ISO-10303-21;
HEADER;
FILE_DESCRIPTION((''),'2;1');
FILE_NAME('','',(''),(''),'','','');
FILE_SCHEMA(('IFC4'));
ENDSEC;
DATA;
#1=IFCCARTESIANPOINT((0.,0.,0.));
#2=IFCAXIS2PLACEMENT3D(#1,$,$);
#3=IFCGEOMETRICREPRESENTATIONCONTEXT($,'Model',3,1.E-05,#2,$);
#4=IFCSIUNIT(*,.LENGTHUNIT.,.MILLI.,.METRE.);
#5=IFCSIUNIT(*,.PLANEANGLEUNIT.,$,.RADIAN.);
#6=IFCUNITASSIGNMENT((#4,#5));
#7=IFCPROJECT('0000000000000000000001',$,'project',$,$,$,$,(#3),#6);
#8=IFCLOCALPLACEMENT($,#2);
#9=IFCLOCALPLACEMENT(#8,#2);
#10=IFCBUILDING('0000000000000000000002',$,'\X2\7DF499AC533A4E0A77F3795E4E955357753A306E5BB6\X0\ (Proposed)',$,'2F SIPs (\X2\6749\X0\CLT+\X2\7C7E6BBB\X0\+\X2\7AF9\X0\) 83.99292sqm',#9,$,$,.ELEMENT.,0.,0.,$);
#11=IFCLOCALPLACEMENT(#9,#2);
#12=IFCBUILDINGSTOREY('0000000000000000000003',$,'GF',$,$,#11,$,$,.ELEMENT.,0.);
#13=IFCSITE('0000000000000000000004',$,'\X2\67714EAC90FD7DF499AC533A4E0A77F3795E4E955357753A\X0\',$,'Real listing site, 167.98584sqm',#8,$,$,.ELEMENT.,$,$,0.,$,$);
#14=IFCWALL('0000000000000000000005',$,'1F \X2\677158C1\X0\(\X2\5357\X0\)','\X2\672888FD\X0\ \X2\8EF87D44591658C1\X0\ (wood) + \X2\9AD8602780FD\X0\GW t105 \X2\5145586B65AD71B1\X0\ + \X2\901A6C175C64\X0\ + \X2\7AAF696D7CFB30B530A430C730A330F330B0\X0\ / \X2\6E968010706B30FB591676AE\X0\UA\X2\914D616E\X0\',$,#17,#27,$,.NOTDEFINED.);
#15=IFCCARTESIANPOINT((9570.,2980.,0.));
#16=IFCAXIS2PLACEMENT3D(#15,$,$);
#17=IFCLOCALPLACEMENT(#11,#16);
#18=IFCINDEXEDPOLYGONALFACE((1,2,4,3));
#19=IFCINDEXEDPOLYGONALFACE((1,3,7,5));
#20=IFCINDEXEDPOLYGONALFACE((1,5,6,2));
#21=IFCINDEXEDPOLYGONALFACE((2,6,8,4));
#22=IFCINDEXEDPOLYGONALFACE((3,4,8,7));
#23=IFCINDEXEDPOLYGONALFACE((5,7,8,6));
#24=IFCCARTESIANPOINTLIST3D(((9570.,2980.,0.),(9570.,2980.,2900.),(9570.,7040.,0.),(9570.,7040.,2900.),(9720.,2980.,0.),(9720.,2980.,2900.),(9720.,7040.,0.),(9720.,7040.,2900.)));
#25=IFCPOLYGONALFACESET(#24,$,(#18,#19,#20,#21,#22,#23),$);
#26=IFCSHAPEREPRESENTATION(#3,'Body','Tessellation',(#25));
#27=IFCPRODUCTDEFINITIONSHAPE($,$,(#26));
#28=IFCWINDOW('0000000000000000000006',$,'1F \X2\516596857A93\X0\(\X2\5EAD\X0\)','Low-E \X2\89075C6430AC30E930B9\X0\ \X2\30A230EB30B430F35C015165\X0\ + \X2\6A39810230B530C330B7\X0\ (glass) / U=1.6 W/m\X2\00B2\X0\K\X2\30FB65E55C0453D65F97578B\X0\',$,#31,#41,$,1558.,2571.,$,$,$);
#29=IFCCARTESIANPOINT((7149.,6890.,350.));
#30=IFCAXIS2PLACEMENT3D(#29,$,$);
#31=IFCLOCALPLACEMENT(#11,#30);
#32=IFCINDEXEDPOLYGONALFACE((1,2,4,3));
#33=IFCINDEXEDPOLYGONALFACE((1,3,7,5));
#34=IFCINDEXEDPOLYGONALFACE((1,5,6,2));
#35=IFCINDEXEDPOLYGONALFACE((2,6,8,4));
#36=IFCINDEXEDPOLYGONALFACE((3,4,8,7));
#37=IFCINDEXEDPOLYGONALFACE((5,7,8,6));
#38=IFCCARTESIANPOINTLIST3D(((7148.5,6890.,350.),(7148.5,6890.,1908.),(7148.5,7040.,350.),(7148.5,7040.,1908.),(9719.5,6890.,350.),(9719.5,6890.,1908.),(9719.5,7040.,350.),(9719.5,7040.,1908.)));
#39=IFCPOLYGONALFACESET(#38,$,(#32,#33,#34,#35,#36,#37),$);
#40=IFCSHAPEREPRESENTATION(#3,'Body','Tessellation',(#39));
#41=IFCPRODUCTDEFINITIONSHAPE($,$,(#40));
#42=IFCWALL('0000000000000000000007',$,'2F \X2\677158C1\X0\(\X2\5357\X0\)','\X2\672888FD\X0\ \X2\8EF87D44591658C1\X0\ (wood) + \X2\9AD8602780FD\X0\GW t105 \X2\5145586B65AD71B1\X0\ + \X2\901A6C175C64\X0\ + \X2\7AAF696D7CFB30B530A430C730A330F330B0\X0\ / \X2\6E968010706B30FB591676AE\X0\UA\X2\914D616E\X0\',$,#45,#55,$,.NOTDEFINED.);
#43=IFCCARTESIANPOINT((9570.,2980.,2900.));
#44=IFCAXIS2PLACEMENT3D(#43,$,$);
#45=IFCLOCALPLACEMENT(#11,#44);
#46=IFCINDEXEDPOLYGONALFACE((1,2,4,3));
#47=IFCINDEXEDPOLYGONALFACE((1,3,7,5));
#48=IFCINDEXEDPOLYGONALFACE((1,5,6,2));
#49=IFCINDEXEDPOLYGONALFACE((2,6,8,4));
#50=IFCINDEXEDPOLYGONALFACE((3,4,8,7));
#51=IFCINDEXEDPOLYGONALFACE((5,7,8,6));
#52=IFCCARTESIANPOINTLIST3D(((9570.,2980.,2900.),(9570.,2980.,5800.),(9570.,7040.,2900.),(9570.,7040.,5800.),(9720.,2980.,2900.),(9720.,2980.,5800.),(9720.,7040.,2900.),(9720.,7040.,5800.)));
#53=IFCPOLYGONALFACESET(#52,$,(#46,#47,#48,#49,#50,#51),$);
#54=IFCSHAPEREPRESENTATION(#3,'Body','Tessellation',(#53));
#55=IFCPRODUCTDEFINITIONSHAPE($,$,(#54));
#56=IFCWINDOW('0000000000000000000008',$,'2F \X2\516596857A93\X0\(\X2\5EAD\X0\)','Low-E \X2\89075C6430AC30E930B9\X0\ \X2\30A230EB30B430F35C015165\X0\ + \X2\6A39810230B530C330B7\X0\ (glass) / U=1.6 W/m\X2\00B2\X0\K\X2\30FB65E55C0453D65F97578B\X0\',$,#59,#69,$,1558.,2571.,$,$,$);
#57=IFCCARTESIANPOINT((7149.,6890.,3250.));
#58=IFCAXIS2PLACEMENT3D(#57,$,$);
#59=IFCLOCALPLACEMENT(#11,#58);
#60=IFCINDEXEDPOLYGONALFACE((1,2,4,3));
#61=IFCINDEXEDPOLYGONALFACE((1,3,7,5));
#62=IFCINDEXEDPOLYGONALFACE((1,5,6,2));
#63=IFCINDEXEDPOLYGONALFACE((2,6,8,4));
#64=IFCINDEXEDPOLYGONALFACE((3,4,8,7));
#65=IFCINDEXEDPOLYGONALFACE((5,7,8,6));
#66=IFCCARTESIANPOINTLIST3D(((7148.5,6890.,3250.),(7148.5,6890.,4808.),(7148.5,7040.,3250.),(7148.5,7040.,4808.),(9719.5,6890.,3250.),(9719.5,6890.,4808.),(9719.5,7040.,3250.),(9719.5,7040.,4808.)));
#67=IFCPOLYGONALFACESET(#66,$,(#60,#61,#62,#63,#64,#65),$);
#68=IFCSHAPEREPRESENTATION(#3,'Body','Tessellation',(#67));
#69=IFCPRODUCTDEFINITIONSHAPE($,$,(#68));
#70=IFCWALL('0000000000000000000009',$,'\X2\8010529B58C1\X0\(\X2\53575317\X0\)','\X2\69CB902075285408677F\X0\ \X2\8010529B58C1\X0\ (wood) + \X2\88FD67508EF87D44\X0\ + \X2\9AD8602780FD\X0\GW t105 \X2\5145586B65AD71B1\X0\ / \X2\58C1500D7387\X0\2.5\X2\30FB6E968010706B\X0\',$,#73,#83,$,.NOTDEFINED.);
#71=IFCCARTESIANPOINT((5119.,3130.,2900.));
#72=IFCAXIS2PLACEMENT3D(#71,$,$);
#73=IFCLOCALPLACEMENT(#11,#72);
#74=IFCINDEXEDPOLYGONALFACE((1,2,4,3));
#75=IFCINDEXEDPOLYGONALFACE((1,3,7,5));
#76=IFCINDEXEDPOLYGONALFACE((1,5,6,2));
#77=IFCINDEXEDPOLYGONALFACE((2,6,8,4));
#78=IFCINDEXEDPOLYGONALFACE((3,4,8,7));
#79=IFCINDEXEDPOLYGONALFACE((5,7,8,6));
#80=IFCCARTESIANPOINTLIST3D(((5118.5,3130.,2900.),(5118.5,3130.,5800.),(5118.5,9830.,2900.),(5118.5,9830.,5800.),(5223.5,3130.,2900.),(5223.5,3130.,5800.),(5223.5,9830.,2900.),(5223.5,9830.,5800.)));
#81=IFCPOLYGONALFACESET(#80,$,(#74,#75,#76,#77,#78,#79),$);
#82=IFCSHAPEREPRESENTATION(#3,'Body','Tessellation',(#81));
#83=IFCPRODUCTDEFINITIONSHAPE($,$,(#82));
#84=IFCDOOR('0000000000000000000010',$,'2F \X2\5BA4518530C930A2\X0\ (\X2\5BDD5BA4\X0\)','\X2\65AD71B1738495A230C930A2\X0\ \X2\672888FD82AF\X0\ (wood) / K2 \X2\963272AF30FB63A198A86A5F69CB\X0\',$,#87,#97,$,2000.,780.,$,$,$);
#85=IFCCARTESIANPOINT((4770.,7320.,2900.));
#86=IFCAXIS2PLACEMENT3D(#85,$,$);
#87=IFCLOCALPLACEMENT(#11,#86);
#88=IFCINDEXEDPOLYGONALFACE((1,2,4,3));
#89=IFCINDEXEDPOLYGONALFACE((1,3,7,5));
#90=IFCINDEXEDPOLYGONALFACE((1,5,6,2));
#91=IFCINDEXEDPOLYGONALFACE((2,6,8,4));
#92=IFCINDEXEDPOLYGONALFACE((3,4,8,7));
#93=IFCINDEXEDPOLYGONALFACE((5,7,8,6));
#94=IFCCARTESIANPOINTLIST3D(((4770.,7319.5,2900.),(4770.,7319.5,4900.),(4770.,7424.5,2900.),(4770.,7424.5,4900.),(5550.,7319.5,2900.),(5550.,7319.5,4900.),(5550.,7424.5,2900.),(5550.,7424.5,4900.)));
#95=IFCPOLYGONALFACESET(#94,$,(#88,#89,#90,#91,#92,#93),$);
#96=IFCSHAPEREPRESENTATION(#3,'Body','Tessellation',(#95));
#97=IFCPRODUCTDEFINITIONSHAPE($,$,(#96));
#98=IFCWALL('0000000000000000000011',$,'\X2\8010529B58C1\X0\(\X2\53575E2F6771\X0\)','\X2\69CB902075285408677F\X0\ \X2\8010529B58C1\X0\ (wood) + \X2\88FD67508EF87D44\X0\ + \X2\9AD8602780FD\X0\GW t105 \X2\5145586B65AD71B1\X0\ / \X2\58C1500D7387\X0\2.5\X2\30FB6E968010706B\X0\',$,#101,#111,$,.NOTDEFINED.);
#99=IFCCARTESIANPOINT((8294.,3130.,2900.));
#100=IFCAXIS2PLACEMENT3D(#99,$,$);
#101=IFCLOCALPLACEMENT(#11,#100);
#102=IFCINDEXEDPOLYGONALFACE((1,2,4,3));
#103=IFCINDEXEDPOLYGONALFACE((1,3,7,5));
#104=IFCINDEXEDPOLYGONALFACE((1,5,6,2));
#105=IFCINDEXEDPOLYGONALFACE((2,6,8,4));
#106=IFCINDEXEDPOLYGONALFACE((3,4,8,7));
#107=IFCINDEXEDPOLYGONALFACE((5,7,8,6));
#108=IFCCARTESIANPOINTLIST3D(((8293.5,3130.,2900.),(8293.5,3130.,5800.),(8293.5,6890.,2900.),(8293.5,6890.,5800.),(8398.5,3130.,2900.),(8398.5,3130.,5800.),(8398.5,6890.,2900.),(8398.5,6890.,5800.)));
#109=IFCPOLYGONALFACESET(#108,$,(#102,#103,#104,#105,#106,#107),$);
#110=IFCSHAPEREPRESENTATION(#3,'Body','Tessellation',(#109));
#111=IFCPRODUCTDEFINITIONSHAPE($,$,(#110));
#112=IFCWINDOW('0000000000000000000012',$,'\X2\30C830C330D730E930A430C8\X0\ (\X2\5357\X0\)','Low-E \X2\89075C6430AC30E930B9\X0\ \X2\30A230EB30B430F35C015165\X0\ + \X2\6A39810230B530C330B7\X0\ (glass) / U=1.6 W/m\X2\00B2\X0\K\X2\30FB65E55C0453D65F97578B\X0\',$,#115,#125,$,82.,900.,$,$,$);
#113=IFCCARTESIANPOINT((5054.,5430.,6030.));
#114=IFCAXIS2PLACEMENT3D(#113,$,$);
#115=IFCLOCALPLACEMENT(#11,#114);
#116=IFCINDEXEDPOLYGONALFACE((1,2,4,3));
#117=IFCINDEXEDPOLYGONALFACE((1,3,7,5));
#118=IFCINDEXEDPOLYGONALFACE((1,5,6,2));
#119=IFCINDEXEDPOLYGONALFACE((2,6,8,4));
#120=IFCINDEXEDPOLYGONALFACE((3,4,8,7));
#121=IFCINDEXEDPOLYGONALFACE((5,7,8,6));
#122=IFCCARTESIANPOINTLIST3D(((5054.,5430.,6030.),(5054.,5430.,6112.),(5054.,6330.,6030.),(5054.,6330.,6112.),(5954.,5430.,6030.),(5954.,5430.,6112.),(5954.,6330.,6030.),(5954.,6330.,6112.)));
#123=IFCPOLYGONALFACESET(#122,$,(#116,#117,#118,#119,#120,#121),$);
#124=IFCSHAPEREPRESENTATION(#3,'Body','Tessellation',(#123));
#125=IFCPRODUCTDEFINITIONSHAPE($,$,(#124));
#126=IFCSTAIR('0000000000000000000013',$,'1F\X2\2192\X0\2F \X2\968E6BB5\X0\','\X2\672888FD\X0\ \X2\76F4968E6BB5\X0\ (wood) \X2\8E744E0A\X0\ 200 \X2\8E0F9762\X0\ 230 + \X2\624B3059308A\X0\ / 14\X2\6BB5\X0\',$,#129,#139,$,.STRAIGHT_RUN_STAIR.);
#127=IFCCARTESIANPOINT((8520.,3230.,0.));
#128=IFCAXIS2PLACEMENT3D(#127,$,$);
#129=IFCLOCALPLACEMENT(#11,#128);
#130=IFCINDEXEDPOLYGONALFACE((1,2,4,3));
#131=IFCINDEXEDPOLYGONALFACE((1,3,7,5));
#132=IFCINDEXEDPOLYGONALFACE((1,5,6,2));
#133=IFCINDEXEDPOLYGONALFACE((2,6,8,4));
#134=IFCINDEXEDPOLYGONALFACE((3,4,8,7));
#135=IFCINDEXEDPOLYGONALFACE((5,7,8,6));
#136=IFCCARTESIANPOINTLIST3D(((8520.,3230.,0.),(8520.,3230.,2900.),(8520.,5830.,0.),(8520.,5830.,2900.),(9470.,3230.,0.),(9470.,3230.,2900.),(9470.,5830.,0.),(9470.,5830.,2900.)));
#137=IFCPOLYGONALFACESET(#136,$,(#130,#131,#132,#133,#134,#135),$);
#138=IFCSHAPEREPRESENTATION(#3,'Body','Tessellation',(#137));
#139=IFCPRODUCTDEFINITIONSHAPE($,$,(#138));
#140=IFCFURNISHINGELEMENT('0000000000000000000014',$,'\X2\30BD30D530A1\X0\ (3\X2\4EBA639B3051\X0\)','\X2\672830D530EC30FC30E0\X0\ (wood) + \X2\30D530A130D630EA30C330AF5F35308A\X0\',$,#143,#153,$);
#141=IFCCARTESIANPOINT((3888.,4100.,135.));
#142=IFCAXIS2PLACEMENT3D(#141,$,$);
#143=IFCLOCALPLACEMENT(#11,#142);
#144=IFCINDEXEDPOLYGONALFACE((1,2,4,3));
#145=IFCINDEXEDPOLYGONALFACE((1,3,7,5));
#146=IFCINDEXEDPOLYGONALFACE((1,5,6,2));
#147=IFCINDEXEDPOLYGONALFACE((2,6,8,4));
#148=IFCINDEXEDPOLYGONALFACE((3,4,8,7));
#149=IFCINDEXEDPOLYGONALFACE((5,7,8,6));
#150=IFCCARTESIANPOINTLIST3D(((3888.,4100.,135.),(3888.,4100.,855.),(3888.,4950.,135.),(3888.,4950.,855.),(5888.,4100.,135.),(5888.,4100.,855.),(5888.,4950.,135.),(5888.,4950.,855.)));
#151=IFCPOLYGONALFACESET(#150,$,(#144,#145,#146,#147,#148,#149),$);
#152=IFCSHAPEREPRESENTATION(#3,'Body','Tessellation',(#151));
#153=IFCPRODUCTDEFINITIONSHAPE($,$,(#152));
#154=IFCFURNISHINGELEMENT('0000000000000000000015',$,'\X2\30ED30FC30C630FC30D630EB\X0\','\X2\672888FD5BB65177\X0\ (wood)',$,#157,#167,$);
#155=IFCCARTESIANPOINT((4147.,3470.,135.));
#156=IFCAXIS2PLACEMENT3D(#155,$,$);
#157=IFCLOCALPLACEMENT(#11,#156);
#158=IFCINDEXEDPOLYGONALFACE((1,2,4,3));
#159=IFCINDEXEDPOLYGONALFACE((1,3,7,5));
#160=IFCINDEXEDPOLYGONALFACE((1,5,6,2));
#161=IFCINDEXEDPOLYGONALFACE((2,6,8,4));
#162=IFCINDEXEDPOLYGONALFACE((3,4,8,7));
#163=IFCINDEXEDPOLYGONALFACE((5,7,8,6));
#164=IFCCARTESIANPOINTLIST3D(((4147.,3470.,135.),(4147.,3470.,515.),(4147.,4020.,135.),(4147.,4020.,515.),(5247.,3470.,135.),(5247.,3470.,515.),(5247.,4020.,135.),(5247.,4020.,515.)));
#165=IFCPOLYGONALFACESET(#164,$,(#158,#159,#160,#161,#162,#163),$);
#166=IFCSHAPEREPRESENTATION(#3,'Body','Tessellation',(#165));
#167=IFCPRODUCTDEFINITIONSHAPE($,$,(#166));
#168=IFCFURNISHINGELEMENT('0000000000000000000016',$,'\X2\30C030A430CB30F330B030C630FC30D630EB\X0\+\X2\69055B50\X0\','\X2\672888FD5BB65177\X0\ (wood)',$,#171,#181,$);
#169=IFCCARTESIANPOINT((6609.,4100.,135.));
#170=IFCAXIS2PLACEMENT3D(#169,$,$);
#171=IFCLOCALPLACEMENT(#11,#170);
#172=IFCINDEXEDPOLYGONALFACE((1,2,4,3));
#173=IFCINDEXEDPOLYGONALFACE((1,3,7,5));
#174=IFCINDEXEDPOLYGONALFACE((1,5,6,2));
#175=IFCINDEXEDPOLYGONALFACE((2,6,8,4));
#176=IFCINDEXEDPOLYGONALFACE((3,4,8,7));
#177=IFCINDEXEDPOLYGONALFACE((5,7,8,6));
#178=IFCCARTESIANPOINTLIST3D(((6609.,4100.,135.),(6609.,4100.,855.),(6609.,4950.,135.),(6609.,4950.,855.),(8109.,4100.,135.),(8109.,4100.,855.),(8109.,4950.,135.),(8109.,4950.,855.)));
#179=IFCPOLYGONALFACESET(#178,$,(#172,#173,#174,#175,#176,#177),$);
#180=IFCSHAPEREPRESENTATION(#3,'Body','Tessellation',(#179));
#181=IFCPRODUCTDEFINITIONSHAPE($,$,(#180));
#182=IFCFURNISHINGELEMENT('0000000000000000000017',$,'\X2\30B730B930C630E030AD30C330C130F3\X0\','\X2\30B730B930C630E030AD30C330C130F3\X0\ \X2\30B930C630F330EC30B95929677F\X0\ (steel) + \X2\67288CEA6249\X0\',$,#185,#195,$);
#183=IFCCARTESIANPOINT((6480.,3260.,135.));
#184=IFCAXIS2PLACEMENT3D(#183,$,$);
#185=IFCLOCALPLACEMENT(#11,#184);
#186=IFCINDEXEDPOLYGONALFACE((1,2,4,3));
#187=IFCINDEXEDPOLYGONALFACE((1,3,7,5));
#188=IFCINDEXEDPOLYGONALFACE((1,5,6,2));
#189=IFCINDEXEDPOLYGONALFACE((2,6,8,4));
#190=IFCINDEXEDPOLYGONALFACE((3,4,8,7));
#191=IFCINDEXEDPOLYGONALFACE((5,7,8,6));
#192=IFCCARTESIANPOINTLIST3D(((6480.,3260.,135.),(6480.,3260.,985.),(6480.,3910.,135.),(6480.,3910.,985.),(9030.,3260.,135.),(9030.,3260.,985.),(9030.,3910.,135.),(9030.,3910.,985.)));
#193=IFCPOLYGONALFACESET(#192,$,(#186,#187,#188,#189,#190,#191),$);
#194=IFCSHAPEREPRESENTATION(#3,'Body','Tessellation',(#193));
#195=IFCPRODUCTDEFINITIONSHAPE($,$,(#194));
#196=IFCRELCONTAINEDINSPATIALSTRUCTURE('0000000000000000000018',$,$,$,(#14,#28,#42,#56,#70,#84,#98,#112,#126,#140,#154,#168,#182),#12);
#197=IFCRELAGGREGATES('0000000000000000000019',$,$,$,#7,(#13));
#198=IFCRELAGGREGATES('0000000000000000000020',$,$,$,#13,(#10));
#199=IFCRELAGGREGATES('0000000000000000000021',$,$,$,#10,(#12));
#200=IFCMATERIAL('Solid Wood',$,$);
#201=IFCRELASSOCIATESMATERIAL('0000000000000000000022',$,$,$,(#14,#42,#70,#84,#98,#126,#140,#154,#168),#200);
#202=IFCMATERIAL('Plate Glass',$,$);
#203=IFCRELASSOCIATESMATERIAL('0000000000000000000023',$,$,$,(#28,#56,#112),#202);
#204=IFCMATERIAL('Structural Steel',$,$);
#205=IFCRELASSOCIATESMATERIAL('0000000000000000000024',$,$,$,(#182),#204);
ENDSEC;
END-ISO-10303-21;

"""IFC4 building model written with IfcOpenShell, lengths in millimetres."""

from ifc_helpers import new_model, si_unit, frame, frame_2d, origin, place, context, project, spatial, rectangle, extrude, material, element, fill, save


model = new_model("IFC4")

# Units and contexts
model_context = context("Model", 3, precision=1e-05, world=origin())
ifc_project = project(units=[si_unit("LENGTHUNIT", "METRE", prefix="MILLI"), si_unit("PLANEANGLEUNIT", "RADIAN")], contexts=[model_context])

# Site, building, storey
site_placement = place(None, origin())
site = spatial("IfcSite", under=ifc_project, at=site_placement, Name="東京都練馬区上石神井南町", ObjectType="Real listing site, 167.98584sqm", CompositionType="ELEMENT", RefElevation=0.0)
building_placement = place(site_placement, origin())
building = spatial("IfcBuilding", under=site, at=building_placement, Name="練馬区上石神井南町の家 (Proposed)", ObjectType="2F SIPs (杉CLT+籾殻+竹) 83.99292sqm", CompositionType="ELEMENT", ElevationOfRefHeight=0.0, ElevationOfTerrain=0.0)
storey_placement = place(building_placement, origin())
storey = spatial("IfcBuildingStorey", under=building, at=storey_placement, Name="GF", CompositionType="ELEMENT", Elevation=0.0)

# Wall, opening, window
ifc_material_1 = material(Name="Solid Wood")
wall_1_placement = place(storey_placement, frame((9570.0, 2980.0, 0.0)))
wall_1 = element("IfcWall", 1, at=wall_1_placement, inside=storey, material=ifc_material_1, Name="1F 東壁(南)", Description="木製 軸組外壁 (wood) + 高性能GW t105 充填断熱 + 通気層 + 窯業系サイディング / 準耐火・外皮UA配慮", PredefinedType="NOTDEFINED", context=model_context, shape_type="SweptSolid", body=[
    extrude(rectangle(XDim=150.0, YDim=4060.0, at=frame_2d((75.0, 2030.0))), frame((9570.0, 2980.0, 0.0)), (0.0, 0.0, 1.0), 2900.0),
])
opening_1_placement = place(storey_placement, frame((7149.0, 6890.0, 350.0)))
opening_1 = element("IfcOpeningElement", 2, at=opening_1_placement, cuts=wall_1, PredefinedType="NOTDEFINED", context=model_context, shape_type="SweptSolid", body=[
    extrude(rectangle(XDim=2571.0, YDim=150.0, at=frame_2d((1285.0, 75.0))), frame((7149.0, 6890.0, 350.0)), (0.0, 0.0, 1.0), 1558.0),
])
ifc_material_2 = material(Name="Plate Glass")
window_1_placement = place(storey_placement, frame((7149.0, 6890.0, 350.0)))
window_1 = element("IfcWindow", 3, at=window_1_placement, inside=storey, material=ifc_material_2, Name="1F 入隅窓(庭)", Description="Low-E 複層ガラス アルゴン封入 + 樹脂サッシ (glass) / U=1.6 W/m²K・日射取得型", OverallHeight=1558.0, OverallWidth=2571.0, context=model_context, shape_type="SweptSolid", body=[
    extrude(rectangle(XDim=2571.0, YDim=150.0, at=frame_2d((1285.0, 75.0))), frame((7149.0, 6890.0, 350.0)), (0.0, 0.0, 1.0), 1558.0),
])
fill(opening_1, window_1)

# Wall, opening, window
wall_2_placement = place(storey_placement, frame((9570.0, 2980.0, 2900.0)))
wall_2 = element("IfcWall", 4, at=wall_2_placement, inside=storey, material=ifc_material_1, Name="2F 東壁(南)", Description="木製 軸組外壁 (wood) + 高性能GW t105 充填断熱 + 通気層 + 窯業系サイディング / 準耐火・外皮UA配慮", PredefinedType="NOTDEFINED", context=model_context, shape_type="SweptSolid", body=[
    extrude(rectangle(XDim=150.0, YDim=4060.0, at=frame_2d((75.0, 2030.0))), frame((9570.0, 2980.0, 2900.0)), (0.0, 0.0, 1.0), 2900.0),
])
opening_2_placement = place(storey_placement, frame((7149.0, 6890.0, 3250.0)))
opening_2 = element("IfcOpeningElement", 5, at=opening_2_placement, cuts=wall_2, PredefinedType="NOTDEFINED", context=model_context, shape_type="SweptSolid", body=[
    extrude(rectangle(XDim=2571.0, YDim=150.0, at=frame_2d((1285.0, 75.0))), frame((7149.0, 6890.0, 3250.0)), (0.0, 0.0, 1.0), 1558.0),
])
window_2_placement = place(storey_placement, frame((7149.0, 6890.0, 3250.0)))
window_2 = element("IfcWindow", 6, at=window_2_placement, inside=storey, material=ifc_material_2, Name="2F 入隅窓(庭)", Description="Low-E 複層ガラス アルゴン封入 + 樹脂サッシ (glass) / U=1.6 W/m²K・日射取得型", OverallHeight=1558.0, OverallWidth=2571.0, context=model_context, shape_type="SweptSolid", body=[
    extrude(rectangle(XDim=2571.0, YDim=150.0, at=frame_2d((1285.0, 75.0))), frame((7149.0, 6890.0, 3250.0)), (0.0, 0.0, 1.0), 1558.0),
])
fill(opening_2, window_2)

# Wall, opening, door
wall_3_placement = place(storey_placement, frame((5119.0, 3130.0, 2900.0)))
wall_3 = element("IfcWall", 7, at=wall_3_placement, inside=storey, material=ifc_material_1, Name="耐力壁(南北)", Description="構造用合板 耐力壁 (wood) + 製材軸組 + 高性能GW t105 充填断熱 / 壁倍率2.5・準耐火", PredefinedType="NOTDEFINED", context=model_context, shape_type="SweptSolid", body=[
    extrude(rectangle(XDim=105.0, YDim=6700.0, at=frame_2d((52.0, 3350.0))), frame((5119.0, 3130.0, 2900.0)), (0.0, 0.0, 1.0), 2900.0),
])
opening_3_placement = place(storey_placement, frame((4770.0, 7320.0, 2900.0)))
opening_3 = element("IfcOpeningElement", 8, at=opening_3_placement, cuts=wall_3, PredefinedType="NOTDEFINED", context=model_context, shape_type="SweptSolid", body=[
    extrude(rectangle(XDim=780.0, YDim=105.0, at=frame_2d((390.0, 52.0))), frame((4770.0, 7320.0, 2900.0)), (0.0, 0.0, 1.0), 2000.0),
])
door_1_placement = place(storey_placement, frame((4770.0, 7320.0, 2900.0)))
door_1 = element("IfcDoor", 9, at=door_1_placement, inside=storey, material=ifc_material_1, Name="2F 室内ドア (寝室)", Description="断熱玄関ドア 木製芯 (wood) / K2 防犯・採風機構", OverallHeight=2000.0, OverallWidth=780.0, context=model_context, shape_type="SweptSolid", body=[
    extrude(rectangle(XDim=780.0, YDim=105.0, at=frame_2d((390.0, 52.0))), frame((4770.0, 7320.0, 2900.0)), (0.0, 0.0, 1.0), 2000.0),
])
fill(opening_3, door_1)

# Wall
wall_4_placement = place(storey_placement, frame((8294.0, 3130.0, 2900.0)))
element("IfcWall", 10, at=wall_4_placement, inside=storey, material=ifc_material_1, Name="耐力壁(南帯東)", Description="構造用合板 耐力壁 (wood) + 製材軸組 + 高性能GW t105 充填断熱 / 壁倍率2.5・準耐火", PredefinedType="NOTDEFINED", context=model_context, shape_type="SweptSolid", body=[
    extrude(rectangle(XDim=105.0, YDim=3760.0, at=frame_2d((52.0, 1880.0))), frame((8294.0, 3130.0, 2900.0)), (0.0, 0.0, 1.0), 2900.0),
])

# Window
window_3_placement = place(storey_placement, frame((5054.0, 5430.0, 6030.0)))
element("IfcWindow", 11, at=window_3_placement, inside=storey, material=ifc_material_2, Name="トップライト (南)", Description="Low-E 複層ガラス アルゴン封入 + 樹脂サッシ (glass) / U=1.6 W/m²K・日射取得型", OverallHeight=82.0, OverallWidth=900.0, context=model_context, shape_type="SweptSolid", body=[
    extrude(rectangle(XDim=900.0, YDim=900.0, at=frame_2d((450.0, 450.0))), frame((5054.0, 5430.0, 6030.0)), (0.0, 0.0, 1.0), 82.0),
])

# Stair
stair_placement = place(storey_placement, frame((8520.0, 3230.0, 0.0)))
element("IfcStair", 12, at=stair_placement, inside=storey, material=ifc_material_1, Name="1F→2F 階段", Description="木製 直階段 (wood) 蹴上 200 踏面 230 + 手すり / 14段", PredefinedType="STRAIGHT_RUN_STAIR", context=model_context, shape_type="SweptSolid", body=[
    extrude(rectangle(XDim=950.0, YDim=2600.0, at=frame_2d((475.0, 1300.0))), frame((8520.0, 3230.0, 0.0)), (0.0, 0.0, 1.0), 2900.0),
])

# Furnishing elements
furnishing_1_placement = place(storey_placement, frame((3888.0, 4100.0, 135.0)))
element("IfcFurnishingElement", 13, at=furnishing_1_placement, inside=storey, material=ifc_material_1, Name="ソファ (3人掛け)", Description="木フレーム (wood) + ファブリック張り", context=model_context, shape_type="SweptSolid", body=[
    extrude(rectangle(XDim=2000.0, YDim=850.0, at=frame_2d((1000.0, 425.0))), frame((3888.0, 4100.0, 135.0)), (0.0, 0.0, 1.0), 720.0),
])
furnishing_2_placement = place(storey_placement, frame((4147.0, 3470.0, 135.0)))
element("IfcFurnishingElement", 14, at=furnishing_2_placement, inside=storey, material=ifc_material_1, Name="ローテーブル", Description="木製家具 (wood)", context=model_context, shape_type="SweptSolid", body=[
    extrude(rectangle(XDim=1100.0, YDim=550.0, at=frame_2d((550.0, 275.0))), frame((4147.0, 3470.0, 135.0)), (0.0, 0.0, 1.0), 380.0),
])
furnishing_3_placement = place(storey_placement, frame((6609.0, 4100.0, 135.0)))
element("IfcFurnishingElement", 15, at=furnishing_3_placement, inside=storey, material=ifc_material_1, Name="ダイニングテーブル+椅子", Description="木製家具 (wood)", context=model_context, shape_type="SweptSolid", body=[
    extrude(rectangle(XDim=1500.0, YDim=850.0, at=frame_2d((750.0, 425.0))), frame((6609.0, 4100.0, 135.0)), (0.0, 0.0, 1.0), 720.0),
])
ifc_material_3 = material(Name="Structural Steel")
furnishing_4_placement = place(storey_placement, frame((6480.0, 3260.0, 135.0)))
element("IfcFurnishingElement", 16, at=furnishing_4_placement, inside=storey, material=ifc_material_3, Name="システムキッチン", Description="システムキッチン ステンレス天板 (steel) + 木質扉", context=model_context, shape_type="SweptSolid", body=[
    extrude(rectangle(XDim=2550.0, YDim=650.0, at=frame_2d((1275.0, 325.0))), frame((6480.0, 3260.0, 135.0)), (0.0, 0.0, 1.0), 850.0),
])

save(model, "model.ifc")
